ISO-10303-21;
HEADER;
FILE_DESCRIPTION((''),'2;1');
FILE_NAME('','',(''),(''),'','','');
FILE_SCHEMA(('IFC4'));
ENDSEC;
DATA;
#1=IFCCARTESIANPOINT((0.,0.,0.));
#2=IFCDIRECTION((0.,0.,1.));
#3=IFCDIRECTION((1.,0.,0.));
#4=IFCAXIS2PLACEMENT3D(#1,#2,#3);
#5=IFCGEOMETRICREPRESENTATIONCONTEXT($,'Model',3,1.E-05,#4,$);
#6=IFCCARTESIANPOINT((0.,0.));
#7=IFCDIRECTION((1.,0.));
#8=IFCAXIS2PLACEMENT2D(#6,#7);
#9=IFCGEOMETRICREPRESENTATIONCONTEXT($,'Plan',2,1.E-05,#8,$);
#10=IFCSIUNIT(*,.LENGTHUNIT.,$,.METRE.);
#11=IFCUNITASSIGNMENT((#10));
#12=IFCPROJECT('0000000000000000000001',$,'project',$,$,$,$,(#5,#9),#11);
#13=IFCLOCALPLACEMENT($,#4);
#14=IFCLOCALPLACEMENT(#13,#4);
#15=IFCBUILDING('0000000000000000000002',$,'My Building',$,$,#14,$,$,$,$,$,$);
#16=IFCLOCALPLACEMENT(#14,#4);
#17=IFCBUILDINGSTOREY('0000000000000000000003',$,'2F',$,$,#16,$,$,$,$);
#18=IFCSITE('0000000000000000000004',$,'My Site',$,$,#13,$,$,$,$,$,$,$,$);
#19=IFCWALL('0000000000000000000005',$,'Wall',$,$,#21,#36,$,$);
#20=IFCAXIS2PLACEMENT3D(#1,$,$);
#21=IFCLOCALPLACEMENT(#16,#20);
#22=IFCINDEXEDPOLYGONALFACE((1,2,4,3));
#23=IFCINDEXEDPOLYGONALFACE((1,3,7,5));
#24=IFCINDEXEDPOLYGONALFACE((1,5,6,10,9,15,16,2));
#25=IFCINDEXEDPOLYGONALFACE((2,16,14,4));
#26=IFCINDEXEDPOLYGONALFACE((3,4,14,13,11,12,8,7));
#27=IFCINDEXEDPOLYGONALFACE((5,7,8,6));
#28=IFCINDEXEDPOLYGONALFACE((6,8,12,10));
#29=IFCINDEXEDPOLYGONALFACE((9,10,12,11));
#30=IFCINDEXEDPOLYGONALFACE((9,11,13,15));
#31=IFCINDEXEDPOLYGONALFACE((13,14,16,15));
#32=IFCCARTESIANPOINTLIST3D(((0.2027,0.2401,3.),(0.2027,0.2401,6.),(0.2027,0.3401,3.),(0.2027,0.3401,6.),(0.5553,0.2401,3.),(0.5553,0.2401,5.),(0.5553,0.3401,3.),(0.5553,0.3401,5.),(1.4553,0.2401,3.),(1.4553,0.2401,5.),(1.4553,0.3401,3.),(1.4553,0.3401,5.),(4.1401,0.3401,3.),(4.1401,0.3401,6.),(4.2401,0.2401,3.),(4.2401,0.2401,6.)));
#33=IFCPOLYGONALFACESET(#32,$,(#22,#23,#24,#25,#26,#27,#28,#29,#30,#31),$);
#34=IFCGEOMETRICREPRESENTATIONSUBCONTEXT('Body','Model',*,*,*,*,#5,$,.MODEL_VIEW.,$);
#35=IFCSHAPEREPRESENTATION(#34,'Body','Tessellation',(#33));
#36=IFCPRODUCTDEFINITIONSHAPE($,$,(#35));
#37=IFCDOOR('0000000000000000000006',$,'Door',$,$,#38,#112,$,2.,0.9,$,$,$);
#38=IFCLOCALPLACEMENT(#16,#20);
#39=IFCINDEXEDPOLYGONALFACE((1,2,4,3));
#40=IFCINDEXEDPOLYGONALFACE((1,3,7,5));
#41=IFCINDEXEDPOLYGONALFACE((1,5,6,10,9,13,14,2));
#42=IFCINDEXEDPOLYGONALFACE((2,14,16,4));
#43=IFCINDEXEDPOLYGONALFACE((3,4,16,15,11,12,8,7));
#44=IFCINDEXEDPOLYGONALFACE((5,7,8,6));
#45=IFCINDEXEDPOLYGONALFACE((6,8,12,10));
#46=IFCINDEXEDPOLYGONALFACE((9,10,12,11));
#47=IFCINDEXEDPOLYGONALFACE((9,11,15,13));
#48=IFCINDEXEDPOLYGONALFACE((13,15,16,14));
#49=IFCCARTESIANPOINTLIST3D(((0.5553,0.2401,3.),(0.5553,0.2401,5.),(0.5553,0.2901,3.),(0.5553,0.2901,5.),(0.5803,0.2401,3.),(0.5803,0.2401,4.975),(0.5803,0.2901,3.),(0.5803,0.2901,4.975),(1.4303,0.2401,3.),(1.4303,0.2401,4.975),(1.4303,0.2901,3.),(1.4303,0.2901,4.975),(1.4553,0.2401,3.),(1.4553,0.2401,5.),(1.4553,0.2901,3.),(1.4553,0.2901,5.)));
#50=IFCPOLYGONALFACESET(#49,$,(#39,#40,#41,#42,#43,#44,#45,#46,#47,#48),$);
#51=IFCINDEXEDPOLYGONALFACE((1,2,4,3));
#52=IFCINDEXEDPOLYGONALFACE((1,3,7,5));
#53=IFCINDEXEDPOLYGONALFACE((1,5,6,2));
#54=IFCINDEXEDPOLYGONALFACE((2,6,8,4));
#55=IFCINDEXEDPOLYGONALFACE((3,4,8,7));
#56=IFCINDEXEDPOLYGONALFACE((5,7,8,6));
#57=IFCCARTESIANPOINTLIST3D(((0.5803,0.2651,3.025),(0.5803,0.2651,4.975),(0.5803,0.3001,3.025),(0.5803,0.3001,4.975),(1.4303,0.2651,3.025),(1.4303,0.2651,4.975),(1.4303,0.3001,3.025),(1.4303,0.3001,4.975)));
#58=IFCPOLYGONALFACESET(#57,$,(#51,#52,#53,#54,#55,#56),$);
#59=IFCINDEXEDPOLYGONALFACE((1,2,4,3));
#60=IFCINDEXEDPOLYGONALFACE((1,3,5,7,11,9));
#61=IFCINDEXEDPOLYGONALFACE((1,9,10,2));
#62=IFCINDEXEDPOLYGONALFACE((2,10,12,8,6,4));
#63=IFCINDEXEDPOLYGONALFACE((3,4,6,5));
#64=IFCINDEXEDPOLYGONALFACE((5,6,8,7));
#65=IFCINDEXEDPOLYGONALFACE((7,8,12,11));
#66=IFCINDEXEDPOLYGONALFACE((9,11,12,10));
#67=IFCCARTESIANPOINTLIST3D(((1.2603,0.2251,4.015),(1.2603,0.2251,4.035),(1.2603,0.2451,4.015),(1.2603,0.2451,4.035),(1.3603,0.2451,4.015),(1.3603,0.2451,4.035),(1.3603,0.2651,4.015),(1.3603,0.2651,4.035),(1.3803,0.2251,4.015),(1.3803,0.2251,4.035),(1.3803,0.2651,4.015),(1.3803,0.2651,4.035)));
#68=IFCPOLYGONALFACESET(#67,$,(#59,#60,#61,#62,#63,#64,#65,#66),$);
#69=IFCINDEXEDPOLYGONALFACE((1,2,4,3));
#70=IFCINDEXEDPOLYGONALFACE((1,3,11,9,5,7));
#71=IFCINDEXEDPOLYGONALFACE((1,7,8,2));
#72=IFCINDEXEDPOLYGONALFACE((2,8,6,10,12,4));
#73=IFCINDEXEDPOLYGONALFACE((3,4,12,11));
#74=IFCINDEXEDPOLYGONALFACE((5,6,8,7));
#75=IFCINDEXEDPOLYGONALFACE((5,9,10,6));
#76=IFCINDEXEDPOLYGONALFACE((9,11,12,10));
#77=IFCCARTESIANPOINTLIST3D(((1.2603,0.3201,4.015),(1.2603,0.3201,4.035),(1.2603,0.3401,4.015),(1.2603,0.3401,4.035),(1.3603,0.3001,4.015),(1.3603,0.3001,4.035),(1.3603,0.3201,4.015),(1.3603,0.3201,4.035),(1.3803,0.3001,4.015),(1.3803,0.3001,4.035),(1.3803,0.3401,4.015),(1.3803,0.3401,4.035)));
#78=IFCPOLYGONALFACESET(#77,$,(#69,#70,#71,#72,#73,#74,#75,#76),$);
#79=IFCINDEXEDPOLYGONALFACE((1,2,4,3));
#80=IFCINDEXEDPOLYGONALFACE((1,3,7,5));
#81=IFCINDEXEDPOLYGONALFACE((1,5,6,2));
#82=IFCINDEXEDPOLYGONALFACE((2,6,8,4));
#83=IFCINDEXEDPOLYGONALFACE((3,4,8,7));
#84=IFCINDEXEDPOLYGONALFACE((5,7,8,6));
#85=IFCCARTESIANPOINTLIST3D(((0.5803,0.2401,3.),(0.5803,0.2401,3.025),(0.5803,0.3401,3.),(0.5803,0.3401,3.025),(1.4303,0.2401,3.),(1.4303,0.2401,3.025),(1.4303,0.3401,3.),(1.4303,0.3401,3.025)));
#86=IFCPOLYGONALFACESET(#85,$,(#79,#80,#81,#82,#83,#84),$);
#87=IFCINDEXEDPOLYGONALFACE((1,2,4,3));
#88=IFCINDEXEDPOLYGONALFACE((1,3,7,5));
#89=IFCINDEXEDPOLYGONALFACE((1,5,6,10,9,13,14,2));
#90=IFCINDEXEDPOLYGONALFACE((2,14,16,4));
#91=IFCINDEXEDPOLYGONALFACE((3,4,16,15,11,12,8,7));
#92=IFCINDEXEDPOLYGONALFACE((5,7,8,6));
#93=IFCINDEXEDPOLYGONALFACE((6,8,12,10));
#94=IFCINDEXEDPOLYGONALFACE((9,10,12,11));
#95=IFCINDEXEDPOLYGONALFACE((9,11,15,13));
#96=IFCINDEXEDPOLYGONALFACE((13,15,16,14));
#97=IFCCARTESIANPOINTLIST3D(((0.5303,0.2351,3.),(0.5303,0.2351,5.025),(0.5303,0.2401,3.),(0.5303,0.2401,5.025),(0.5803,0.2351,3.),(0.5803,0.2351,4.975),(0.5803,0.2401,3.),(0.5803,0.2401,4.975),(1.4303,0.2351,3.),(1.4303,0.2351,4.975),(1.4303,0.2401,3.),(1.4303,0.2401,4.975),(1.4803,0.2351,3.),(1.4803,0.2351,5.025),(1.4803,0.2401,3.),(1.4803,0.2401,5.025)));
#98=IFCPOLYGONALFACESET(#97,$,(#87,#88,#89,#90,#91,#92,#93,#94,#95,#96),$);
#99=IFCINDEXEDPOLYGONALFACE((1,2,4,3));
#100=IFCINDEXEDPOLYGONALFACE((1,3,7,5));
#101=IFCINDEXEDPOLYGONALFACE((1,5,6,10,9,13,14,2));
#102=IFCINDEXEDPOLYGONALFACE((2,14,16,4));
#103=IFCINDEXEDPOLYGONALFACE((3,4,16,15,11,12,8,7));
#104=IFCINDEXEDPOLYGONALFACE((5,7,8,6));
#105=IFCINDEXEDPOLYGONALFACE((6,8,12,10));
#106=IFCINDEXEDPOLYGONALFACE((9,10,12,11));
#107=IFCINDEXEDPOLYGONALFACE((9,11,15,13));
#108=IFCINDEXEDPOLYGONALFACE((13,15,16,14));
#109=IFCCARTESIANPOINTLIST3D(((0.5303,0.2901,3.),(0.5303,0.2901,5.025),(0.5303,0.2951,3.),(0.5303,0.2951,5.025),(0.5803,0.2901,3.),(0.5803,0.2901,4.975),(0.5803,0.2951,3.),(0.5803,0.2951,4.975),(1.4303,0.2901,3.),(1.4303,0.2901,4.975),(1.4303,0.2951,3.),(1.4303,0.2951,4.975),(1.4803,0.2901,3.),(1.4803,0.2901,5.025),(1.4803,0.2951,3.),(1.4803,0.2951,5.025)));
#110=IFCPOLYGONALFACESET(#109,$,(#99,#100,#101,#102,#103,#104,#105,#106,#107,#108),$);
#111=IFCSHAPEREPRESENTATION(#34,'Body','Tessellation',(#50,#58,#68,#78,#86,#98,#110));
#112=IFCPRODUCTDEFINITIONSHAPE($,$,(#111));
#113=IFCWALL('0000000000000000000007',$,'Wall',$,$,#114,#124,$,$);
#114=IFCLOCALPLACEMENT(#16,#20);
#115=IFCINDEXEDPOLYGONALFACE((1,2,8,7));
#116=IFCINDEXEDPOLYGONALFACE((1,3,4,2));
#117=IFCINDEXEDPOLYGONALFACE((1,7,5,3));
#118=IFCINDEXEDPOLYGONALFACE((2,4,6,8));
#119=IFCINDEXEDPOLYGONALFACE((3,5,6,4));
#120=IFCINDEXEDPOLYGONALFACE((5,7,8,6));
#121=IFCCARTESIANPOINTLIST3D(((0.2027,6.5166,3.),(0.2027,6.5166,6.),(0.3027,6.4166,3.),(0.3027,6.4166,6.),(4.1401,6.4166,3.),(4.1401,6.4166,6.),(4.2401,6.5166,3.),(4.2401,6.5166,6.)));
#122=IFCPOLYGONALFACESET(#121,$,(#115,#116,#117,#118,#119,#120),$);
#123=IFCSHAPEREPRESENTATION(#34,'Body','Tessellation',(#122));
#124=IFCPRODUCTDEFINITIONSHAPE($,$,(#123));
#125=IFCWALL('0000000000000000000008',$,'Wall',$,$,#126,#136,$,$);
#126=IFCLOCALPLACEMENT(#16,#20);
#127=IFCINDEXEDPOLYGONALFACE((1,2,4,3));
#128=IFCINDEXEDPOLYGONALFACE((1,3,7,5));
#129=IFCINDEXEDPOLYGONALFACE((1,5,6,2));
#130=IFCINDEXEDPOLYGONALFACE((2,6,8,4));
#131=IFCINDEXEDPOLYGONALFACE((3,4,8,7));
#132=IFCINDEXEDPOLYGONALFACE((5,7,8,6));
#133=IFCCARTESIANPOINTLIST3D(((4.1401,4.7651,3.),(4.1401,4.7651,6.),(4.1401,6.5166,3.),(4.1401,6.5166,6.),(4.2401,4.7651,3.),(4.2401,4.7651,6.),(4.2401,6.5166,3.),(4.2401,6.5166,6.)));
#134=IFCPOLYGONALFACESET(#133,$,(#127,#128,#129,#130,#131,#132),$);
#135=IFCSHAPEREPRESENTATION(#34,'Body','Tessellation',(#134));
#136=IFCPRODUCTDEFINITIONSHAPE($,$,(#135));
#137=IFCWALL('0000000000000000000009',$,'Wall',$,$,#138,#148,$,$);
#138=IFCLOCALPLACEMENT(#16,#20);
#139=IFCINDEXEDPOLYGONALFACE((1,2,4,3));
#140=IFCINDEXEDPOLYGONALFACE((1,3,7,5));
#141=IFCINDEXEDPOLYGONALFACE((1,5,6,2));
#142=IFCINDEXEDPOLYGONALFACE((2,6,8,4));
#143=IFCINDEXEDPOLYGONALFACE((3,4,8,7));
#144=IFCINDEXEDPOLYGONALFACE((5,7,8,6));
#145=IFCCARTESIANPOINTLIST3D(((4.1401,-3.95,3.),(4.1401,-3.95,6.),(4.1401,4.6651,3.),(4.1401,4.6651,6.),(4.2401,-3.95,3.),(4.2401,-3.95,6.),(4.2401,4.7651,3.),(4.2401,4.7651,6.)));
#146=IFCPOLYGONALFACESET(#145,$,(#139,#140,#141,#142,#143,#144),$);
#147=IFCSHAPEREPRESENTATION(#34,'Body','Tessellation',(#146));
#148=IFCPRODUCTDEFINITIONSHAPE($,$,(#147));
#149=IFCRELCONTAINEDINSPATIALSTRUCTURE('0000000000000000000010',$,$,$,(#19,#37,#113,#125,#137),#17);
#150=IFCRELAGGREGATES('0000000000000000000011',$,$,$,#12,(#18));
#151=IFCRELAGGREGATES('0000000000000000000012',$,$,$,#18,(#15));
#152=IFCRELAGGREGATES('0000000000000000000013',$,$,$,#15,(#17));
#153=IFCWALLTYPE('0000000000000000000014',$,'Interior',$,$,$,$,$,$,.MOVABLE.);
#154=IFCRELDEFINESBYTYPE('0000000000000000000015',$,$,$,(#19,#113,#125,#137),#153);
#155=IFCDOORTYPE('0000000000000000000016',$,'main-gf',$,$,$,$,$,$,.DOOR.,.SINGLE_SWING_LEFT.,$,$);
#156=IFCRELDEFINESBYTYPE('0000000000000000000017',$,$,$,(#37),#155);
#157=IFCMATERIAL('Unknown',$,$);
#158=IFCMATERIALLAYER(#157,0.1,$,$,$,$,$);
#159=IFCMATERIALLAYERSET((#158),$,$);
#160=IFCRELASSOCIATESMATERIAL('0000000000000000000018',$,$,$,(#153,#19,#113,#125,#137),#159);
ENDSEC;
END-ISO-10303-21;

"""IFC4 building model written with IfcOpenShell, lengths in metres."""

from ifc_helpers import new_model, entity, si_unit, frame, origin_with_axes, origin_2d_with_axis, place, context, subcontext, project, spatial, line, indexed_curve, outline, extrude, shape, source, transform, mapped, material, layer, layer_set, layer_usage, type_object, type_shapes, element, fill, save


model = new_model("IFC4")

# Units and contexts
model_context = context("Model", 3, precision=1e-05, world=origin_with_axes())
plan_context = context("Plan", 2, precision=1e-05, world=origin_2d_with_axis())
body_context_1 = subcontext(model_context, "Body", "Model", "MODEL_VIEW")
body_context_2 = subcontext(plan_context, "Body", "Plan", "PLAN_VIEW")
ifc_project = project(units=[si_unit("LENGTHUNIT", "METRE")], contexts=[model_context, plan_context])

# Site, building, storey
site_placement = place(None, origin_with_axes())
site = spatial("IfcSite", under=ifc_project, at=site_placement, Name="My Site")
building_placement = place(site_placement, origin_with_axes())
building = spatial("IfcBuilding", under=site, at=building_placement, Name="My Building")
storey_placement = place(building_placement, origin_with_axes())
storey = spatial("IfcBuildingStorey", under=building, at=storey_placement, Name="2F")

# Shared definitions
ifc_material = material(Name="Unknown")

# Shared definitions
ifc_layer_1 = layer(ifc_material, 0.1)
ifc_layer_set_1 = layer_set([ifc_layer_1])
wall_type = type_object("IfcWallType", Name="Interior", PredefinedType="MOVABLE", material=ifc_layer_set_1)

# Shared definitions
shared_shape_1 = source(origin_with_axes(), body_context_1, "Body", "SweptSolid", [
    extrude(outline(indexed_curve([(0.0, 0.0), (0.9, 0.0), (0.9, 2.0), (0.0, 2.0)], segments=[line(1, 2, 3, 4, 1)])), frame((0.0, -0.6, 0.0), z_axis=(0.0, -1.0, 0.0), x_axis=(1.0, 0.0, 0.0)), (0.0, 0.0, -1.0), 1.2),
])
door_type = type_object("IfcDoorType", Name="main-gf", OperationType="SINGLE_SWING_LEFT", PredefinedType="DOOR")
shared_shape_2 = source(origin_with_axes(), body_context_1, "Body", "SweptSolid", [
    extrude(outline(indexed_curve([(0.0, 0.0), (0.0, 2.0), (0.9, 2.0), (0.9, 0.0), (0.875, 0.0), (0.875, 1.975), (0.025, 1.975), (0.025, 0.0)], segments=[line(1, 2, 3, 4, 5, 6, 7, 8, 1)])), frame((0.0, 0.0, 0.0), z_axis=(0.0, -1.0, 0.0), x_axis=(1.0, 0.0, 0.0)), (0.0, 0.0, -1.0), 0.05),
    extrude(outline(indexed_curve([(0.0, 0.0), (0.85, 0.0), (0.85, 0.035), (0.0, 0.035)], segments=[line(1, 2, 3, 4, 1)])), frame((0.025, 0.025, 0.025), z_axis=(0.0, 0.0, 1.0), x_axis=(1.0, 0.0, 0.0)), (0.0, 0.0, 1.0), 1.95),
    extrude(outline(indexed_curve([(0.0, 0.0), (0.0, -0.04), (-0.12, -0.04), (-0.12, -0.02), (-0.02, -0.02), (-0.02, 0.0)], segments=[line(1, 2, 3, 4, 5, 6, 1)])), frame((0.825, 0.025, 1.015), z_axis=(0.0, 0.0, 1.0), x_axis=(1.0, 0.0, 0.0)), (0.0, 0.0, 1.0), 0.02),
    extrude(outline(indexed_curve([(0.0, 0.0), (0.0, 0.04), (-0.12, 0.04), (-0.12, 0.02), (-0.02, 0.02), (-0.02, 0.0)], segments=[line(1, 2, 3, 4, 5, 6, 1)])), frame((0.825, 0.06, 1.015), z_axis=(0.0, 0.0, 1.0), x_axis=(1.0, 0.0, 0.0)), (0.0, 0.0, 1.0), 0.02),
    extrude(outline(indexed_curve([(0.0, 0.0), (0.85, 0.0), (0.85, 0.1), (0.0, 0.1)], segments=[line(1, 2, 3, 4, 1)])), frame((0.025, 0.0, 0.0), z_axis=(0.0, 0.0, 1.0), x_axis=(1.0, 0.0, 0.0)), (0.0, 0.0, 1.0), 0.025),
    extrude(outline(indexed_curve([(0.0, 0.0), (0.0, 2.025), (0.95, 2.025), (0.95, 0.0), (0.9, 0.0), (0.9, 1.975), (0.05, 1.975), (0.05, 0.0)], segments=[line(1, 2, 3, 4, 5, 6, 7, 8, 1)])), frame((-0.025, -0.005, 0.0), z_axis=(0.0, -1.0, 0.0), x_axis=(1.0, 0.0, 0.0)), (0.0, 0.0, -1.0), 0.005),
    extrude(outline(indexed_curve([(0.0, 0.0), (0.0, 2.025), (0.95, 2.025), (0.95, 0.0), (0.9, 0.0), (0.9, 1.975), (0.05, 1.975), (0.05, 0.0)], segments=[line(1, 2, 3, 4, 5, 6, 7, 8, 1)])), frame((-0.025, 0.05, 0.0), z_axis=(0.0, -1.0, 0.0), x_axis=(1.0, 0.0, 0.0)), (0.0, 0.0, -1.0), 0.005),
])
shared_shape_3 = source(origin_with_axes(), body_context_2, "Body", "Curve2D", [
    entity("IfcIndexedPolyCurve", entity("IfcCartesianPointList2D", [[0.0, 0.0], [0.025, 0.0], [0.025, 0.05], [0.0, 0.05]]), [entity("IfcLineIndex", [1, 2, 3, 4, 1])]),
    entity("IfcIndexedPolyCurve", entity("IfcCartesianPointList2D", [[0.9, 0.0], [0.875, 0.0], [0.875, 0.05], [0.9, 0.05]]), [entity("IfcLineIndex", [1, 2, 3, 4, 1])]),
    entity("IfcIndexedPolyCurve", entity("IfcCartesianPointList2D", [[0.025, 0.05], [0.025, -0.8], [0.06, -0.8]])),
    entity("IfcTrimmedCurve", entity("IfcEllipse", entity("IfcAxis2Placement2D", entity("IfcCartesianPoint", [0.06, 0.05]), entity("IfcDirection", [1.0, 0.0])), 0.815, 0.85), [entity("IfcCartesianPoint", [0.06, -0.8])], [entity("IfcCartesianPoint", [0.06, 0.9])], True, "CARTESIAN"),
    entity("IfcIndexedPolyCurve", entity("IfcCartesianPointList2D", [[0.025, 0.05], [0.06, 0.05], [0.06, 0.9], [0.025, 0.9]]), [entity("IfcLineIndex", [1, 2, 3, 4, 1])]),
])
type_shapes(door_type, [shared_shape_2, shared_shape_3])

# Wall, opening, door
ifc_layer_usage_1 = layer_usage(ifc_layer_set_1, "AXIS2", "POSITIVE", 0.0)
wall_1_placement = place(storey_placement, frame((4.1401, 0.3401, 3.0), z_axis=(0.0, 0.0, 1.0), x_axis=(-1.0, 0.0, 0.0)))
wall_1 = element("IfcWall", 1, at=wall_1_placement, inside=storey, type_object=wall_type, material=ifc_layer_usage_1, Name="Wall", context=body_context_1, shape_type="SweptSolid", body=[
    extrude(outline(indexed_curve([(0.0, 0.0), (-0.1, 0.1), (3.9374, 0.1), (3.9374, 0.0)], segments=[line(1, 2, 3, 4, 1)])), origin_with_axes(), (0.0, 0.0, 1.0), 3.0),
])
opening_1_placement = place(wall_1_placement, frame((3.5848, 0.1, 0.0), z_axis=(0.0, 0.0, 1.0), x_axis=(-1.0, 0.0, 0.0)))
opening_1 = element("IfcOpeningElement", 2, at=opening_1_placement, cuts=wall_1, PredefinedType="OPENING", context=body_context_1, shape_type="MappedRepresentation", body=[
    mapped(shared_shape_1, transform((0.0, 0.0, 0.0), x_axis=(1.0, 0.0, 0.0), y_axis=(0.0, 1.0, 0.0), z_axis=(0.0, 0.0, 1.0), scale=1.0)),
])
door_1_placement = place(opening_1_placement, frame((0.0, 0.0, 0.0), z_axis=(0.0, 0.0, 1.0), x_axis=(1.0, 0.0, 0.0)))
door_1 = element("IfcDoor", 3, at=door_1_placement, inside=storey, type_object=door_type, Name="Door", OverallHeight=2.0, OverallWidth=0.9, shapes=[
    shape(body_context_1, "Body", "MappedRepresentation", [mapped(shared_shape_2, transform((0.0, 0.0, 0.0), x_axis=(1.0, 0.0, 0.0), y_axis=(0.0, 1.0, 0.0), z_axis=(0.0, 0.0, 1.0), scale=1.0))]),
    shape(body_context_2, "Body", "MappedRepresentation", [mapped(shared_shape_3, transform((0.0, 0.0, 0.0), x_axis=(1.0, 0.0, 0.0), y_axis=(0.0, 1.0, 0.0), z_axis=(0.0, 0.0, 1.0), scale=1.0))]),
])
fill(opening_1, door_1)

# Walls
ifc_layer_usage_2 = layer_usage(ifc_layer_set_1, "AXIS2", "POSITIVE", 0.0)
wall_2_placement = place(storey_placement, frame((4.2401, 6.5166, 3.0), z_axis=(0.0, 0.0, 1.0), x_axis=(-1.0, 0.0, 0.0)))
element("IfcWall", 4, at=wall_2_placement, inside=storey, type_object=wall_type, material=ifc_layer_usage_2, Name="Wall", context=body_context_1, shape_type="SweptSolid", body=[
    extrude(outline(indexed_curve([(0.0, 0.0), (0.1, 0.1), (3.9373, 0.1), (4.0373, 0.0)], segments=[line(1, 2, 3, 4, 1)])), origin_with_axes(), (0.0, 0.0, 1.0), 3.0),
])
ifc_layer_usage_3 = layer_usage(ifc_layer_set_1, "AXIS2", "POSITIVE", 0.0)
wall_3_placement = place(storey_placement, frame((4.2401, 4.7651, 3.0), z_axis=(0.0, 0.0, 1.0), x_axis=(0.0, 1.0, 0.0)))
element("IfcWall", 5, at=wall_3_placement, inside=storey, type_object=wall_type, material=ifc_layer_usage_3, Name="Wall", context=body_context_1, shape_type="SweptSolid", body=[
    extrude(outline(indexed_curve([(0.0, 0.0), (0.0, 0.1), (1.7515, 0.1), (1.7515, 0.0)], segments=[line(1, 2, 3, 4, 1)])), origin_with_axes(), (0.0, 0.0, 1.0), 3.0),
])
ifc_layer_usage_4 = layer_usage(ifc_layer_set_1, "AXIS2", "POSITIVE", 0.0)
wall_4_placement = place(storey_placement, frame((4.1401, 4.7651, 3.0), z_axis=(0.0, 0.0, 1.0), x_axis=(0.0, -1.0, 0.0)))
element("IfcWall", 6, at=wall_4_placement, inside=storey, type_object=wall_type, material=ifc_layer_usage_4, Name="Wall", context=body_context_1, shape_type="SweptSolid", body=[
    extrude(outline(indexed_curve([(0.1, 0.0), (0.0, 0.1), (8.7151, 0.1), (8.7151, 0.0)], segments=[line(1, 2, 3, 4, 1)])), origin_with_axes(), (0.0, 0.0, 1.0), 3.0),
])

save(model, "model.ifc")
